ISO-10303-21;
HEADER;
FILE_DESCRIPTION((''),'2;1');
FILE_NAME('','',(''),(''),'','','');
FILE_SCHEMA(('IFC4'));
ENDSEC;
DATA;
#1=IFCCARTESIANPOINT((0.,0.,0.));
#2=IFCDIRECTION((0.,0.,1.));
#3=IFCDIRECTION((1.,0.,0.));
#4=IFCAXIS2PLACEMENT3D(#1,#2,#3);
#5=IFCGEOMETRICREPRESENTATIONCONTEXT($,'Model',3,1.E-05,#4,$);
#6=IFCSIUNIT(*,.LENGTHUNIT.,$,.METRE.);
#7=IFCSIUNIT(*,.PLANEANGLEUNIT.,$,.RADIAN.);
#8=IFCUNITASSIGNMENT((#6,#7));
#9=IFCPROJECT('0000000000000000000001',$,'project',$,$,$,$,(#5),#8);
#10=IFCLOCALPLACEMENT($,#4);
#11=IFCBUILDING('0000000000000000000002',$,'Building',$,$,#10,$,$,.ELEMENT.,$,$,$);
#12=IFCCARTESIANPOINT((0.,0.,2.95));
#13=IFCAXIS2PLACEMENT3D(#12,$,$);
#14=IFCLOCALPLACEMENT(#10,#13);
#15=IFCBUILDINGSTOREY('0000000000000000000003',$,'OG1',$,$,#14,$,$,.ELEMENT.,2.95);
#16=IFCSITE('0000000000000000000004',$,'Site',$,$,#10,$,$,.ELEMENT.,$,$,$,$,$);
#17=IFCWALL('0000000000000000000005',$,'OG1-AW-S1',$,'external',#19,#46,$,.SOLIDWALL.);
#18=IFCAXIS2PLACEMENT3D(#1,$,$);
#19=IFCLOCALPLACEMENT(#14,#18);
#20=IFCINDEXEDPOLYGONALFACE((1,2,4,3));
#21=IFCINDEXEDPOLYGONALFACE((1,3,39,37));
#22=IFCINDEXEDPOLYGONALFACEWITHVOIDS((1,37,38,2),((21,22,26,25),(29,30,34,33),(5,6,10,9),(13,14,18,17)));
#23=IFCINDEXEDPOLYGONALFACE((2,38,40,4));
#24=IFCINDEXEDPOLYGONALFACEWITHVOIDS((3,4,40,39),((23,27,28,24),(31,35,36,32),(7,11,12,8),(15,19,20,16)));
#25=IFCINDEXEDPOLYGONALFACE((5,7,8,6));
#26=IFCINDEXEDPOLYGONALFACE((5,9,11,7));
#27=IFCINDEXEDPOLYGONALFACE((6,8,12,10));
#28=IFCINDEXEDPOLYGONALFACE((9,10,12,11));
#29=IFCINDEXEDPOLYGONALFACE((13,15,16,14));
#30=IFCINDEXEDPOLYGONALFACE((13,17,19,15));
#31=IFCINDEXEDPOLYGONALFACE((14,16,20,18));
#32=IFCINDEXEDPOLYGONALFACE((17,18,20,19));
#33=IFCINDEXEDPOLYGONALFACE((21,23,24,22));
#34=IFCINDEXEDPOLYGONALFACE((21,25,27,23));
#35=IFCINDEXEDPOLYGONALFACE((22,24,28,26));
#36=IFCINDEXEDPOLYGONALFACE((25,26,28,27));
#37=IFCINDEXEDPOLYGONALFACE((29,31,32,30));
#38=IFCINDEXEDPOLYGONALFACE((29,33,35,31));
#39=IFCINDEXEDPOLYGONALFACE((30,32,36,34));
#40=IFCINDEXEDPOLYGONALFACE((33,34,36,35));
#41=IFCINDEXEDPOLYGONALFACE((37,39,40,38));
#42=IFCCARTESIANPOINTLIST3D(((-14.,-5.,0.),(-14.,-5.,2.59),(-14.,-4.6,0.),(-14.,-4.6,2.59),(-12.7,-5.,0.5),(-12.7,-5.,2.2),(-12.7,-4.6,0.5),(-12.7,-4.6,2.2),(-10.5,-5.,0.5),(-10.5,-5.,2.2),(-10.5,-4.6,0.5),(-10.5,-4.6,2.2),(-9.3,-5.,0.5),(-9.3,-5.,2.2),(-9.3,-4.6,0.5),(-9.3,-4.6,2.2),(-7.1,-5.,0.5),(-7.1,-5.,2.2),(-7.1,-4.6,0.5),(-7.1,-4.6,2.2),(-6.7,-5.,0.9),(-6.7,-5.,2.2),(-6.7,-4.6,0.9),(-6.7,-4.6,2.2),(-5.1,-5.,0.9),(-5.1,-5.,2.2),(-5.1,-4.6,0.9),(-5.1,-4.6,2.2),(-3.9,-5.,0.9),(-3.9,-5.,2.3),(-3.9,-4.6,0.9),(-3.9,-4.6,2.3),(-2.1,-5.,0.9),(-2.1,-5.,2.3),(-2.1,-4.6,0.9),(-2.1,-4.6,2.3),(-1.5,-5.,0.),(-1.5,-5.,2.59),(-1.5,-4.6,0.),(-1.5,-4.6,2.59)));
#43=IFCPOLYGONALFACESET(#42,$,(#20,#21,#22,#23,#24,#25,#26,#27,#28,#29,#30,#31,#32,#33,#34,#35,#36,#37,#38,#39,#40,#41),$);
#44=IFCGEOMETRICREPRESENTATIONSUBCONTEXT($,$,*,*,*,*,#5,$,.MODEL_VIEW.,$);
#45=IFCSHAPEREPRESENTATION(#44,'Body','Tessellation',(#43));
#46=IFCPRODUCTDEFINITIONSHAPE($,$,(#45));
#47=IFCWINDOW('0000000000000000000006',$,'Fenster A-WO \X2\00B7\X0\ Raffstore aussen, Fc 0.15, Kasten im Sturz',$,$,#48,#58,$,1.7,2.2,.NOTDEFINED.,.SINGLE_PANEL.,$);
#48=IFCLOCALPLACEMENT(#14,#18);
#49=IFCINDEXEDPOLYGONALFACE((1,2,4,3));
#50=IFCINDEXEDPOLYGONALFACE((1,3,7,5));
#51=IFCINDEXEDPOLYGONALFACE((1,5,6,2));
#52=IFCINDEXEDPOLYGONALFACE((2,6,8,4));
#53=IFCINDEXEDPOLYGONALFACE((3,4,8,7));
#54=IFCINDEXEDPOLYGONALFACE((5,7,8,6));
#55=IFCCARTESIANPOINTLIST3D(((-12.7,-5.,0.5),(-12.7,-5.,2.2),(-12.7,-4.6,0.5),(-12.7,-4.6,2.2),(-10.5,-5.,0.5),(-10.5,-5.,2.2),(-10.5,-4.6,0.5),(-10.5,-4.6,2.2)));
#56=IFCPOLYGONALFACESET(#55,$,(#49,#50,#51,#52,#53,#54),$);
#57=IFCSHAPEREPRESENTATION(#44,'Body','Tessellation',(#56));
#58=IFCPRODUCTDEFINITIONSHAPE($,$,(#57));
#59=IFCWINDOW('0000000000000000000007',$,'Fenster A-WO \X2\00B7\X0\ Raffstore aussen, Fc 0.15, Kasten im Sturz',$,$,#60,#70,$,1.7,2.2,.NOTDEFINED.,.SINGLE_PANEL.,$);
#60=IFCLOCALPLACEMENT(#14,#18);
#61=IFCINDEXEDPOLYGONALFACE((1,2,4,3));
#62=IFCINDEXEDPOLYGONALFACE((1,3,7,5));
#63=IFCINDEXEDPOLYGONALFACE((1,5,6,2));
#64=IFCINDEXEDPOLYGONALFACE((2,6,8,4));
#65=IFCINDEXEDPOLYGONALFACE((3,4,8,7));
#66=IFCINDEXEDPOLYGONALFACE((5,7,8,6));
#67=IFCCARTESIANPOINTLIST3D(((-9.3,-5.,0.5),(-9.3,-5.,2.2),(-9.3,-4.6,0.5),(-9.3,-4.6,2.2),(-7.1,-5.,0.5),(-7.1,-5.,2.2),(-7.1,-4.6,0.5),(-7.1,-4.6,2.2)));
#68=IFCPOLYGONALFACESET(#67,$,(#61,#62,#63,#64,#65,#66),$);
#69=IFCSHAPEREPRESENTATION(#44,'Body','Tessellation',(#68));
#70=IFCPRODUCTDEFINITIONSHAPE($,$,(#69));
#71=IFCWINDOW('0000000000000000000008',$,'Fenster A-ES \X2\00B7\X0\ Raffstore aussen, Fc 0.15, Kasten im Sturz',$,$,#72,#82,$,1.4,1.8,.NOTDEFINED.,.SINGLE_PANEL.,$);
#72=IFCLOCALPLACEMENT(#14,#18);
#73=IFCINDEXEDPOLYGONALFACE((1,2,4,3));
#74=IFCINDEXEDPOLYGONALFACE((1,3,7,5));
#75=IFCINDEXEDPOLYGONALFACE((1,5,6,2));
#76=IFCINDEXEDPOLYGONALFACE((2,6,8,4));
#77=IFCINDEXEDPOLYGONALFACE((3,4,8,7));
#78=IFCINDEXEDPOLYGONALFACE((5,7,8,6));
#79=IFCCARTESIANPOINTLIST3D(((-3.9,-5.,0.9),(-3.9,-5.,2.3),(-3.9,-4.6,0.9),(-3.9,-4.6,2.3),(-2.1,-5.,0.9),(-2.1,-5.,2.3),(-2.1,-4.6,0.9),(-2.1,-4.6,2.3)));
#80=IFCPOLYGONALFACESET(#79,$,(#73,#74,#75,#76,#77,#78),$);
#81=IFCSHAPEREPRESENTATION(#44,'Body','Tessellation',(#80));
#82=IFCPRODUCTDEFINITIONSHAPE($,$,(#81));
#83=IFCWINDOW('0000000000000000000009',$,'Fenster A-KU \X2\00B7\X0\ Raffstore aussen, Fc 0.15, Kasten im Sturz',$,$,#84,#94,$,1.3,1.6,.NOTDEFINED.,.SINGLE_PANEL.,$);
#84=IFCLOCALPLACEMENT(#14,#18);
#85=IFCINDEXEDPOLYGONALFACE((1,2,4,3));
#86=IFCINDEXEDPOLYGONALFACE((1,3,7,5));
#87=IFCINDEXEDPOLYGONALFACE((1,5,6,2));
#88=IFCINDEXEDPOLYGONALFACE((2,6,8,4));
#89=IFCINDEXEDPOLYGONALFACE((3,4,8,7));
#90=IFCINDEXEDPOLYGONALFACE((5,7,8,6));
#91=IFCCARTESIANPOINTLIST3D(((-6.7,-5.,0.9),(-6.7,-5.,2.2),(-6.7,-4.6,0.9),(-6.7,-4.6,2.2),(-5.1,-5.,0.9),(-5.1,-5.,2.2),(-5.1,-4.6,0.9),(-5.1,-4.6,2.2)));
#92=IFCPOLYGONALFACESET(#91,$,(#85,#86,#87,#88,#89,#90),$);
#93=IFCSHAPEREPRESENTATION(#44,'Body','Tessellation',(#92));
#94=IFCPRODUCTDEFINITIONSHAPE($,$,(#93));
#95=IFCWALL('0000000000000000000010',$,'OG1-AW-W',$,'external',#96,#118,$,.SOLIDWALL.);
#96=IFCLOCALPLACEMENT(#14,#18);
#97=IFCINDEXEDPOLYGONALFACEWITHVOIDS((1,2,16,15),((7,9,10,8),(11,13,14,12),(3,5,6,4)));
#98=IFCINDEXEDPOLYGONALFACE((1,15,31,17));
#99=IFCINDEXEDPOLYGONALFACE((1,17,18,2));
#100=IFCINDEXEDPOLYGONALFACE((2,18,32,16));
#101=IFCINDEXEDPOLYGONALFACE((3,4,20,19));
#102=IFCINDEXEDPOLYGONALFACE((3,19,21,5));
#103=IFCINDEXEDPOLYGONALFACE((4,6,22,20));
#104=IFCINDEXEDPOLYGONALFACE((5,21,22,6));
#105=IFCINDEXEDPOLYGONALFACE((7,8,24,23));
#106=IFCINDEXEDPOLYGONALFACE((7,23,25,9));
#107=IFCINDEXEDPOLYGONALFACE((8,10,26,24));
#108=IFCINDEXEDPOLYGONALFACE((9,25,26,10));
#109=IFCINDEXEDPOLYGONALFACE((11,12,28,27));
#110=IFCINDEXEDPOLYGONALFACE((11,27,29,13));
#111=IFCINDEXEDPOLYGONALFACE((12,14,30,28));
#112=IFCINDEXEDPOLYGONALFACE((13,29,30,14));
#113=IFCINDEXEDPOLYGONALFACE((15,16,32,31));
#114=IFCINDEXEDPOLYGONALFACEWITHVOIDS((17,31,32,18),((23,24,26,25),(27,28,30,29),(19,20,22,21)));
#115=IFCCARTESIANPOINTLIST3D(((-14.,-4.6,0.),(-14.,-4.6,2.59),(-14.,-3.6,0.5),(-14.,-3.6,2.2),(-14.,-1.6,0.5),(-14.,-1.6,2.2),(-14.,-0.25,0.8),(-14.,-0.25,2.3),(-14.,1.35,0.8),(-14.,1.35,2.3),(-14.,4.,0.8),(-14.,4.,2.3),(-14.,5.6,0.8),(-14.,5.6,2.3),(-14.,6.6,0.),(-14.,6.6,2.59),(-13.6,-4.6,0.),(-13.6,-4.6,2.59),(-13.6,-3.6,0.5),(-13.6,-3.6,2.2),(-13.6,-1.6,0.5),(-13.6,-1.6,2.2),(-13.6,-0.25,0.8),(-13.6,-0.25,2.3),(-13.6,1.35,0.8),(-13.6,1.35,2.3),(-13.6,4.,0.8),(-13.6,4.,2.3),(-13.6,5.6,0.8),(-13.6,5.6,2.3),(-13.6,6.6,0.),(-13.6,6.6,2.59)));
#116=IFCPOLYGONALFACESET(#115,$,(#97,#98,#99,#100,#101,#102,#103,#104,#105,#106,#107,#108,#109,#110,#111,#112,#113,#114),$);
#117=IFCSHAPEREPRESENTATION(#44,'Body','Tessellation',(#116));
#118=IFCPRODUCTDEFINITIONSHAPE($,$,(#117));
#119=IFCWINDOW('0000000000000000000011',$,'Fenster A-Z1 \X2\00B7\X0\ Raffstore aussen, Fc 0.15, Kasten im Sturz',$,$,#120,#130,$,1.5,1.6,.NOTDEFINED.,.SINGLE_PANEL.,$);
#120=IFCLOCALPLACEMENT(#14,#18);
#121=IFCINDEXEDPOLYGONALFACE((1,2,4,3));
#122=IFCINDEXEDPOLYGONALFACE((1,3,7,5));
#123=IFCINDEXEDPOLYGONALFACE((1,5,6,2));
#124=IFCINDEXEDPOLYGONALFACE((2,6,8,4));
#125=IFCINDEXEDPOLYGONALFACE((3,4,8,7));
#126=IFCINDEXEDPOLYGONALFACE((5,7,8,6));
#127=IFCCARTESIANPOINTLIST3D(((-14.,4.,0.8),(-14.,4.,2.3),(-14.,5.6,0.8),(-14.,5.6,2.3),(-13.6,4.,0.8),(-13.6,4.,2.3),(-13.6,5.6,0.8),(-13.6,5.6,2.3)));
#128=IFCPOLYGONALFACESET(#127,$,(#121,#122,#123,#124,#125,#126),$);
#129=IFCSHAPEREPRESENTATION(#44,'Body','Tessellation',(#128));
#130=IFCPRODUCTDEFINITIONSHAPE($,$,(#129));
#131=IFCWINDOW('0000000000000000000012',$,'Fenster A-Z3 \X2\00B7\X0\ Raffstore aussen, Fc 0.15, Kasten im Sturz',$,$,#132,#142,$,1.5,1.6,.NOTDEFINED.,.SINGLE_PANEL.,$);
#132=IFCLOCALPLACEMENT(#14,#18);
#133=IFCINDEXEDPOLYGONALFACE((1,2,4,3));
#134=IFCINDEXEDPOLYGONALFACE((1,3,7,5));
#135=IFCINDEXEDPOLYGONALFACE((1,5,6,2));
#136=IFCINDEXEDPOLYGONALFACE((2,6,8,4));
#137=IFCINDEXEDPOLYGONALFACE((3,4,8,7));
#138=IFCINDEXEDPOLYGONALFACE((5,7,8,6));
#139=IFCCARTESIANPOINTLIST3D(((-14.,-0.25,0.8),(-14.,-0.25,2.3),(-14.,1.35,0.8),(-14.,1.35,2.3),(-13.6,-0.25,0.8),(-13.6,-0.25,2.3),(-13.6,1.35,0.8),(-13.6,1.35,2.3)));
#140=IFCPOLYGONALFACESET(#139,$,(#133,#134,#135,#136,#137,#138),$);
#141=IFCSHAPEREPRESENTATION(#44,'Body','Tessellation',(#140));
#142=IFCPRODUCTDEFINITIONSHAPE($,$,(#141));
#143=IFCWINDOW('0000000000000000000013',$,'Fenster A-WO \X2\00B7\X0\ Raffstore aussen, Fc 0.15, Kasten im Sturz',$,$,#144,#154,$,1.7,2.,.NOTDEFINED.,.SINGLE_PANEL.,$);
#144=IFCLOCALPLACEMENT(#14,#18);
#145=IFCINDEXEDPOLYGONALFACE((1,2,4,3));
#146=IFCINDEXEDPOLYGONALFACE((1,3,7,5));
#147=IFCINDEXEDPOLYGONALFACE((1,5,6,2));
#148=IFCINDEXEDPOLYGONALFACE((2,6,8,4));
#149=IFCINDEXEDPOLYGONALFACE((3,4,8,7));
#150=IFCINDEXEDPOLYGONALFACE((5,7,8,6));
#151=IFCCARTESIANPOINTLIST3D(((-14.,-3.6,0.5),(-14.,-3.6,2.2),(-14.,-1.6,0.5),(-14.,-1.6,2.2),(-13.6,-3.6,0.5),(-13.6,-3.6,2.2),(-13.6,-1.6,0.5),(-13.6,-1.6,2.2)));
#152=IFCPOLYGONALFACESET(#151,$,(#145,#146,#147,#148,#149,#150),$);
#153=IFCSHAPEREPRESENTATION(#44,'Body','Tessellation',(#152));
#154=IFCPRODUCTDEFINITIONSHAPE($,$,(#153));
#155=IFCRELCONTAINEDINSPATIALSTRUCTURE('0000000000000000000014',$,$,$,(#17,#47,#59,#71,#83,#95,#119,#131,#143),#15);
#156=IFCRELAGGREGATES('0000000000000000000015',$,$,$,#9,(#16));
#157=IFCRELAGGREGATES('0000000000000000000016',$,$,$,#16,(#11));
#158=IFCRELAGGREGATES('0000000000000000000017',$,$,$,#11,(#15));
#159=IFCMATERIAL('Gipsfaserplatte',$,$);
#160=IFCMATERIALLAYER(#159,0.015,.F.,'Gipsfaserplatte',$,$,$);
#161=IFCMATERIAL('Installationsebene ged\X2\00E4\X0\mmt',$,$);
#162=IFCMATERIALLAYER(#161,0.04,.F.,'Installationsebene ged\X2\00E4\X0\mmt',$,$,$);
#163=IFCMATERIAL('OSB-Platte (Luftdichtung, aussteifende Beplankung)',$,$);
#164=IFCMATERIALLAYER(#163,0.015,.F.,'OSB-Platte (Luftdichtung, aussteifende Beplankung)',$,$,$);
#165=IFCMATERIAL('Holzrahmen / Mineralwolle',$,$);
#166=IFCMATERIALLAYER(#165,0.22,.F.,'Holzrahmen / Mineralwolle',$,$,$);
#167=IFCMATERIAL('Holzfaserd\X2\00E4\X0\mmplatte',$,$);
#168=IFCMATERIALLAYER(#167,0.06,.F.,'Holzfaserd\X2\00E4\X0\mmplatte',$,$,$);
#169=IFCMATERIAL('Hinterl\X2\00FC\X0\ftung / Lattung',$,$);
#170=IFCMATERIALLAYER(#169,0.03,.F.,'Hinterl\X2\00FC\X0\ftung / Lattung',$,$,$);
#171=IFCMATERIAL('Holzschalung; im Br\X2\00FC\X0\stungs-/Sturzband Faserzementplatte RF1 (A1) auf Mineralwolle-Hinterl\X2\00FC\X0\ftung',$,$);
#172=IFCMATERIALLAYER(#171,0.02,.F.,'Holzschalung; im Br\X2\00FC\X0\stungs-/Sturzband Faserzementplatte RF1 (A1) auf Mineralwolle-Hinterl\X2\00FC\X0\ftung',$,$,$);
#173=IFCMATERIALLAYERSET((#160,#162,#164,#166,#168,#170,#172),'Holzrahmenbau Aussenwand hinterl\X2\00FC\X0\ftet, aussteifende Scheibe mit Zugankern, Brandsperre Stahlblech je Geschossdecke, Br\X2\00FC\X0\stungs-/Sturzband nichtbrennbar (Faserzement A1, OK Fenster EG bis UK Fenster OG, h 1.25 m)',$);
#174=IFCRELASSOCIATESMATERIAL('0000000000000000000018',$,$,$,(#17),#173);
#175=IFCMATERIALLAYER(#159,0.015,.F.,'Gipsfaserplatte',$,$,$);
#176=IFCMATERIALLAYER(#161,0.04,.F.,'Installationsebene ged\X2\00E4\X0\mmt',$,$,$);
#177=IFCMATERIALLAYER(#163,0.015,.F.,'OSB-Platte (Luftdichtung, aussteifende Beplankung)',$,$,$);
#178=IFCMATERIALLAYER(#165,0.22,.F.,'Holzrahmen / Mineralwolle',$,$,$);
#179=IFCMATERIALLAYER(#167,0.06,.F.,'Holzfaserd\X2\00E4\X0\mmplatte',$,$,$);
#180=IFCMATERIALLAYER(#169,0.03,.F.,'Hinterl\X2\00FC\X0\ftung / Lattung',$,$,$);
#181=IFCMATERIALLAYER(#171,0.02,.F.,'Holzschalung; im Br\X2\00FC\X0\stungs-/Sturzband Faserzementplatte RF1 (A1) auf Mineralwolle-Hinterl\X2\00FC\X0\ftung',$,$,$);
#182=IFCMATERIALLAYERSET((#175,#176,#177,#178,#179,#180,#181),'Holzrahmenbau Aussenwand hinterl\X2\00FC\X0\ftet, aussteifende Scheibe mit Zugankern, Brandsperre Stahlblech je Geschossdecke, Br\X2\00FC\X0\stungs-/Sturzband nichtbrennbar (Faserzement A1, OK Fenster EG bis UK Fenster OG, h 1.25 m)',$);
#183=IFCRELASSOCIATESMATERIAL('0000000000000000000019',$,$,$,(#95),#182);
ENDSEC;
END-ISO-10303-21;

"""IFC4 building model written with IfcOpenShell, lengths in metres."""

from ifc_helpers import new_model, si_unit, frame, frame_2d, origin, origin_with_axes, place, context, subcontext, project, spatial, rectangle, extrude, material, layer, layer_set, element, fill, save


model = new_model("IFC4")

# Units and contexts
model_context = context("Model", 3, precision=1e-05, world=origin_with_axes())
sub_context = subcontext(model_context, None, None, "MODEL_VIEW")
ifc_project = project(units=[si_unit("LENGTHUNIT", "METRE"), si_unit("PLANEANGLEUNIT", "RADIAN")], contexts=[model_context])

# Site, building, storey
placement = place(None, origin_with_axes())
site = spatial("IfcSite", under=ifc_project, at=placement, Name="Site", CompositionType="ELEMENT")
building = spatial("IfcBuilding", under=site, at=placement, Name="Building", CompositionType="ELEMENT")
storey_placement = place(placement, frame((0.0, 0.0, 2.95)))
storey = spatial("IfcBuildingStorey", under=building, at=storey_placement, Name="OG1", CompositionType="ELEMENT", Elevation=2.95)

# Walls, openings, windows
ifc_material_1 = material(Name="Gipsfaserplatte")
ifc_layer_1 = layer(ifc_material_1, 0.015, ventilated=False, Name="Gipsfaserplatte")
ifc_material_2 = material(Name="Installationsebene gedämmt")
ifc_layer_2 = layer(ifc_material_2, 0.04, ventilated=False, Name="Installationsebene gedämmt")
ifc_material_3 = material(Name="OSB-Platte (Luftdichtung, aussteifende Beplankung)")
ifc_layer_3 = layer(ifc_material_3, 0.015, ventilated=False, Name="OSB-Platte (Luftdichtung, aussteifende Beplankung)")
ifc_material_4 = material(Name="Holzrahmen / Mineralwolle")
ifc_layer_4 = layer(ifc_material_4, 0.22, ventilated=False, Name="Holzrahmen / Mineralwolle")
ifc_material_5 = material(Name="Holzfaserdämmplatte")
ifc_layer_5 = layer(ifc_material_5, 0.06, ventilated=False, Name="Holzfaserdämmplatte")
ifc_material_6 = material(Name="Hinterlüftung / Lattung")
ifc_layer_6 = layer(ifc_material_6, 0.03, ventilated=False, Name="Hinterlüftung / Lattung")
ifc_material_7 = material(Name="Holzschalung; im Brüstungs-/Sturzband Faserzementplatte RF1 (A1) auf Mineralwolle-Hinterlüftung")
ifc_layer_7 = layer(ifc_material_7, 0.02, ventilated=False, Name="Holzschalung; im Brüstungs-/Sturzband Faserzementplatte RF1 (A1) auf Mineralwolle-Hinterlüftung")
ifc_layer_set_1 = layer_set([ifc_layer_1, ifc_layer_2, ifc_layer_3, ifc_layer_4, ifc_layer_5, ifc_layer_6, ifc_layer_7], Name="Holzrahmenbau Aussenwand hinterlüftet, aussteifende Scheibe mit Zugankern, Brandsperre Stahlblech je Geschossdecke, Brüstungs-/Sturzband nichtbrennbar (Faserzement A1, OK Fenster EG bis UK Fenster OG, h 1.25 m)")
wall_1_placement = place(storey_placement, frame((-14.0, -4.8, 0.0), z_axis=(0.0, 0.0, 1.0), x_axis=(1.0, 0.0, 0.0)))
wall_1 = element("IfcWall", 1, at=wall_1_placement, inside=storey, material=ifc_layer_set_1, Name="OG1-AW-S1", ObjectType="external", PredefinedType="SOLIDWALL", context=sub_context, shape_type="SweptSolid", body=[
    extrude(rectangle(XDim=12.5, YDim=0.4, at=frame_2d((6.25, 0.0))), origin(), (0.0, 0.0, 1.0), 2.59),
])
opening_1_placement = place(wall_1_placement, frame((2.4, 0.25, 0.5), z_axis=(0.0, -1.0, 0.0), x_axis=(1.0, 0.0, 0.0)))
opening_1 = element("IfcOpeningElement", 2, at=opening_1_placement, cuts=wall_1, PredefinedType="OPENING", context=sub_context, shape_type="SweptSolid", body=[
    extrude(rectangle(XDim=2.2, YDim=1.7, at=frame_2d((0.0, 0.85))), origin(), (0.0, 0.0, 1.0), 0.5),
])
opening_2_placement = place(wall_1_placement, frame((5.8, 0.25, 0.5), z_axis=(0.0, -1.0, 0.0), x_axis=(1.0, 0.0, 0.0)))
opening_2 = element("IfcOpeningElement", 3, at=opening_2_placement, cuts=wall_1, PredefinedType="OPENING", context=sub_context, shape_type="SweptSolid", body=[
    extrude(rectangle(XDim=2.2, YDim=1.7, at=frame_2d((0.0, 0.85))), origin(), (0.0, 0.0, 1.0), 0.5),
])
opening_3_placement = place(wall_1_placement, frame((11.0, 0.25, 0.9), z_axis=(0.0, -1.0, 0.0), x_axis=(1.0, 0.0, 0.0)))
opening_3 = element("IfcOpeningElement", 4, at=opening_3_placement, cuts=wall_1, PredefinedType="OPENING", context=sub_context, shape_type="SweptSolid", body=[
    extrude(rectangle(XDim=1.8, YDim=1.4, at=frame_2d((0.0, 0.7))), origin(), (0.0, 0.0, 1.0), 0.5),
])
opening_4_placement = place(wall_1_placement, frame((8.1, 0.25, 0.9), z_axis=(0.0, -1.0, 0.0), x_axis=(1.0, 0.0, 0.0)))
opening_4 = element("IfcOpeningElement", 5, at=opening_4_placement, cuts=wall_1, PredefinedType="OPENING", context=sub_context, shape_type="SweptSolid", body=[
    extrude(rectangle(XDim=1.6, YDim=1.3, at=frame_2d((0.0, 0.65))), origin(), (0.0, 0.0, 1.0), 0.5),
])
window_1_placement = place(wall_1_placement, frame((2.4, 0.2, 0.5), z_axis=(0.0, -1.0, 0.0), x_axis=(1.0, 0.0, 0.0)))
window_1 = element("IfcWindow", 6, at=window_1_placement, inside=storey, Name="Fenster A-WO · Raffstore aussen, Fc 0.15, Kasten im Sturz", OverallHeight=1.7, OverallWidth=2.2, PartitioningType="SINGLE_PANEL", PredefinedType="NOTDEFINED", context=sub_context, shape_type="SweptSolid", body=[
    extrude(rectangle(XDim=2.2, YDim=1.7, at=frame_2d((0.0, 0.85))), origin(), (0.0, 0.0, 1.0), 0.4),
])
fill(opening_1, window_1)
window_2_placement = place(wall_1_placement, frame((5.8, 0.2, 0.5), z_axis=(0.0, -1.0, 0.0), x_axis=(1.0, 0.0, 0.0)))
window_2 = element("IfcWindow", 7, at=window_2_placement, inside=storey, Name="Fenster A-WO · Raffstore aussen, Fc 0.15, Kasten im Sturz", OverallHeight=1.7, OverallWidth=2.2, PartitioningType="SINGLE_PANEL", PredefinedType="NOTDEFINED", context=sub_context, shape_type="SweptSolid", body=[
    extrude(rectangle(XDim=2.2, YDim=1.7, at=frame_2d((0.0, 0.85))), origin(), (0.0, 0.0, 1.0), 0.4),
])
fill(opening_2, window_2)
window_3_placement = place(wall_1_placement, frame((11.0, 0.2, 0.9), z_axis=(0.0, -1.0, 0.0), x_axis=(1.0, 0.0, 0.0)))
window_3 = element("IfcWindow", 8, at=window_3_placement, inside=storey, Name="Fenster A-ES · Raffstore aussen, Fc 0.15, Kasten im Sturz", OverallHeight=1.4, OverallWidth=1.8, PartitioningType="SINGLE_PANEL", PredefinedType="NOTDEFINED", context=sub_context, shape_type="SweptSolid", body=[
    extrude(rectangle(XDim=1.8, YDim=1.4, at=frame_2d((0.0, 0.7))), origin(), (0.0, 0.0, 1.0), 0.4),
])
fill(opening_3, window_3)
window_4_placement = place(wall_1_placement, frame((8.1, 0.2, 0.9), z_axis=(0.0, -1.0, 0.0), x_axis=(1.0, 0.0, 0.0)))
window_4 = element("IfcWindow", 9, at=window_4_placement, inside=storey, Name="Fenster A-KU · Raffstore aussen, Fc 0.15, Kasten im Sturz", OverallHeight=1.3, OverallWidth=1.6, PartitioningType="SINGLE_PANEL", PredefinedType="NOTDEFINED", context=sub_context, shape_type="SweptSolid", body=[
    extrude(rectangle(XDim=1.6, YDim=1.3, at=frame_2d((0.0, 0.65))), origin(), (0.0, 0.0, 1.0), 0.4),
])
fill(opening_4, window_4)
ifc_layer_8 = layer(ifc_material_1, 0.015, ventilated=False, Name="Gipsfaserplatte")
ifc_layer_9 = layer(ifc_material_2, 0.04, ventilated=False, Name="Installationsebene gedämmt")
ifc_layer_10 = layer(ifc_material_3, 0.015, ventilated=False, Name="OSB-Platte (Luftdichtung, aussteifende Beplankung)")
ifc_layer_11 = layer(ifc_material_4, 0.22, ventilated=False, Name="Holzrahmen / Mineralwolle")
ifc_layer_12 = layer(ifc_material_5, 0.06, ventilated=False, Name="Holzfaserdämmplatte")
ifc_layer_13 = layer(ifc_material_6, 0.03, ventilated=False, Name="Hinterlüftung / Lattung")
ifc_layer_14 = layer(ifc_material_7, 0.02, ventilated=False, Name="Holzschalung; im Brüstungs-/Sturzband Faserzementplatte RF1 (A1) auf Mineralwolle-Hinterlüftung")
ifc_layer_set_2 = layer_set([ifc_layer_8, ifc_layer_9, ifc_layer_10, ifc_layer_11, ifc_layer_12, ifc_layer_13, ifc_layer_14], Name="Holzrahmenbau Aussenwand hinterlüftet, aussteifende Scheibe mit Zugankern, Brandsperre Stahlblech je Geschossdecke, Brüstungs-/Sturzband nichtbrennbar (Faserzement A1, OK Fenster EG bis UK Fenster OG, h 1.25 m)")
wall_2_placement = place(storey_placement, frame((-13.8, -4.6, 0.0), z_axis=(0.0, 0.0, 1.0), x_axis=(0.0, 1.0, 0.0)))
wall_2 = element("IfcWall", 10, at=wall_2_placement, inside=storey, material=ifc_layer_set_2, Name="OG1-AW-W", ObjectType="external", PredefinedType="SOLIDWALL", context=sub_context, shape_type="SweptSolid", body=[
    extrude(rectangle(XDim=11.2, YDim=0.4, at=frame_2d((5.6, 0.0))), origin(), (0.0, 0.0, 1.0), 2.59),
])
opening_5_placement = place(wall_2_placement, frame((9.4, 0.25, 0.8), z_axis=(0.0, -1.0, 0.0), x_axis=(1.0, 0.0, 0.0)))
opening_5 = element("IfcOpeningElement", 11, at=opening_5_placement, cuts=wall_2, PredefinedType="OPENING", context=sub_context, shape_type="SweptSolid", body=[
    extrude(rectangle(XDim=1.6, YDim=1.5, at=frame_2d((0.0, 0.75))), origin(), (0.0, 0.0, 1.0), 0.5),
])
opening_6_placement = place(wall_2_placement, frame((5.15, 0.25, 0.8), z_axis=(0.0, -1.0, 0.0), x_axis=(1.0, 0.0, 0.0)))
opening_6 = element("IfcOpeningElement", 12, at=opening_6_placement, cuts=wall_2, PredefinedType="OPENING", context=sub_context, shape_type="SweptSolid", body=[
    extrude(rectangle(XDim=1.6, YDim=1.5, at=frame_2d((0.0, 0.75))), origin(), (0.0, 0.0, 1.0), 0.5),
])
opening_7_placement = place(wall_2_placement, frame((2.0, 0.25, 0.5), z_axis=(0.0, -1.0, 0.0), x_axis=(1.0, 0.0, 0.0)))
opening_7 = element("IfcOpeningElement", 13, at=opening_7_placement, cuts=wall_2, PredefinedType="OPENING", context=sub_context, shape_type="SweptSolid", body=[
    extrude(rectangle(XDim=2.0, YDim=1.7, at=frame_2d((0.0, 0.85))), origin(), (0.0, 0.0, 1.0), 0.5),
])
window_5_placement = place(wall_2_placement, frame((9.4, 0.2, 0.8), z_axis=(0.0, -1.0, 0.0), x_axis=(1.0, 0.0, 0.0)))
window_5 = element("IfcWindow", 14, at=window_5_placement, inside=storey, Name="Fenster A-Z1 · Raffstore aussen, Fc 0.15, Kasten im Sturz", OverallHeight=1.5, OverallWidth=1.6, PartitioningType="SINGLE_PANEL", PredefinedType="NOTDEFINED", context=sub_context, shape_type="SweptSolid", body=[
    extrude(rectangle(XDim=1.6, YDim=1.5, at=frame_2d((0.0, 0.75))), origin(), (0.0, 0.0, 1.0), 0.4),
])
fill(opening_5, window_5)
window_6_placement = place(wall_2_placement, frame((5.15, 0.2, 0.8), z_axis=(0.0, -1.0, 0.0), x_axis=(1.0, 0.0, 0.0)))
window_6 = element("IfcWindow", 15, at=window_6_placement, inside=storey, Name="Fenster A-Z3 · Raffstore aussen, Fc 0.15, Kasten im Sturz", OverallHeight=1.5, OverallWidth=1.6, PartitioningType="SINGLE_PANEL", PredefinedType="NOTDEFINED", context=sub_context, shape_type="SweptSolid", body=[
    extrude(rectangle(XDim=1.6, YDim=1.5, at=frame_2d((0.0, 0.75))), origin(), (0.0, 0.0, 1.0), 0.4),
])
fill(opening_6, window_6)
window_7_placement = place(wall_2_placement, frame((2.0, 0.2, 0.5), z_axis=(0.0, -1.0, 0.0), x_axis=(1.0, 0.0, 0.0)))
window_7 = element("IfcWindow", 16, at=window_7_placement, inside=storey, Name="Fenster A-WO · Raffstore aussen, Fc 0.15, Kasten im Sturz", OverallHeight=1.7, OverallWidth=2.0, PartitioningType="SINGLE_PANEL", PredefinedType="NOTDEFINED", context=sub_context, shape_type="SweptSolid", body=[
    extrude(rectangle(XDim=2.0, YDim=1.7, at=frame_2d((0.0, 0.85))), origin(), (0.0, 0.0, 1.0), 0.4),
])
fill(opening_7, window_7)

save(model, "model.ifc")
